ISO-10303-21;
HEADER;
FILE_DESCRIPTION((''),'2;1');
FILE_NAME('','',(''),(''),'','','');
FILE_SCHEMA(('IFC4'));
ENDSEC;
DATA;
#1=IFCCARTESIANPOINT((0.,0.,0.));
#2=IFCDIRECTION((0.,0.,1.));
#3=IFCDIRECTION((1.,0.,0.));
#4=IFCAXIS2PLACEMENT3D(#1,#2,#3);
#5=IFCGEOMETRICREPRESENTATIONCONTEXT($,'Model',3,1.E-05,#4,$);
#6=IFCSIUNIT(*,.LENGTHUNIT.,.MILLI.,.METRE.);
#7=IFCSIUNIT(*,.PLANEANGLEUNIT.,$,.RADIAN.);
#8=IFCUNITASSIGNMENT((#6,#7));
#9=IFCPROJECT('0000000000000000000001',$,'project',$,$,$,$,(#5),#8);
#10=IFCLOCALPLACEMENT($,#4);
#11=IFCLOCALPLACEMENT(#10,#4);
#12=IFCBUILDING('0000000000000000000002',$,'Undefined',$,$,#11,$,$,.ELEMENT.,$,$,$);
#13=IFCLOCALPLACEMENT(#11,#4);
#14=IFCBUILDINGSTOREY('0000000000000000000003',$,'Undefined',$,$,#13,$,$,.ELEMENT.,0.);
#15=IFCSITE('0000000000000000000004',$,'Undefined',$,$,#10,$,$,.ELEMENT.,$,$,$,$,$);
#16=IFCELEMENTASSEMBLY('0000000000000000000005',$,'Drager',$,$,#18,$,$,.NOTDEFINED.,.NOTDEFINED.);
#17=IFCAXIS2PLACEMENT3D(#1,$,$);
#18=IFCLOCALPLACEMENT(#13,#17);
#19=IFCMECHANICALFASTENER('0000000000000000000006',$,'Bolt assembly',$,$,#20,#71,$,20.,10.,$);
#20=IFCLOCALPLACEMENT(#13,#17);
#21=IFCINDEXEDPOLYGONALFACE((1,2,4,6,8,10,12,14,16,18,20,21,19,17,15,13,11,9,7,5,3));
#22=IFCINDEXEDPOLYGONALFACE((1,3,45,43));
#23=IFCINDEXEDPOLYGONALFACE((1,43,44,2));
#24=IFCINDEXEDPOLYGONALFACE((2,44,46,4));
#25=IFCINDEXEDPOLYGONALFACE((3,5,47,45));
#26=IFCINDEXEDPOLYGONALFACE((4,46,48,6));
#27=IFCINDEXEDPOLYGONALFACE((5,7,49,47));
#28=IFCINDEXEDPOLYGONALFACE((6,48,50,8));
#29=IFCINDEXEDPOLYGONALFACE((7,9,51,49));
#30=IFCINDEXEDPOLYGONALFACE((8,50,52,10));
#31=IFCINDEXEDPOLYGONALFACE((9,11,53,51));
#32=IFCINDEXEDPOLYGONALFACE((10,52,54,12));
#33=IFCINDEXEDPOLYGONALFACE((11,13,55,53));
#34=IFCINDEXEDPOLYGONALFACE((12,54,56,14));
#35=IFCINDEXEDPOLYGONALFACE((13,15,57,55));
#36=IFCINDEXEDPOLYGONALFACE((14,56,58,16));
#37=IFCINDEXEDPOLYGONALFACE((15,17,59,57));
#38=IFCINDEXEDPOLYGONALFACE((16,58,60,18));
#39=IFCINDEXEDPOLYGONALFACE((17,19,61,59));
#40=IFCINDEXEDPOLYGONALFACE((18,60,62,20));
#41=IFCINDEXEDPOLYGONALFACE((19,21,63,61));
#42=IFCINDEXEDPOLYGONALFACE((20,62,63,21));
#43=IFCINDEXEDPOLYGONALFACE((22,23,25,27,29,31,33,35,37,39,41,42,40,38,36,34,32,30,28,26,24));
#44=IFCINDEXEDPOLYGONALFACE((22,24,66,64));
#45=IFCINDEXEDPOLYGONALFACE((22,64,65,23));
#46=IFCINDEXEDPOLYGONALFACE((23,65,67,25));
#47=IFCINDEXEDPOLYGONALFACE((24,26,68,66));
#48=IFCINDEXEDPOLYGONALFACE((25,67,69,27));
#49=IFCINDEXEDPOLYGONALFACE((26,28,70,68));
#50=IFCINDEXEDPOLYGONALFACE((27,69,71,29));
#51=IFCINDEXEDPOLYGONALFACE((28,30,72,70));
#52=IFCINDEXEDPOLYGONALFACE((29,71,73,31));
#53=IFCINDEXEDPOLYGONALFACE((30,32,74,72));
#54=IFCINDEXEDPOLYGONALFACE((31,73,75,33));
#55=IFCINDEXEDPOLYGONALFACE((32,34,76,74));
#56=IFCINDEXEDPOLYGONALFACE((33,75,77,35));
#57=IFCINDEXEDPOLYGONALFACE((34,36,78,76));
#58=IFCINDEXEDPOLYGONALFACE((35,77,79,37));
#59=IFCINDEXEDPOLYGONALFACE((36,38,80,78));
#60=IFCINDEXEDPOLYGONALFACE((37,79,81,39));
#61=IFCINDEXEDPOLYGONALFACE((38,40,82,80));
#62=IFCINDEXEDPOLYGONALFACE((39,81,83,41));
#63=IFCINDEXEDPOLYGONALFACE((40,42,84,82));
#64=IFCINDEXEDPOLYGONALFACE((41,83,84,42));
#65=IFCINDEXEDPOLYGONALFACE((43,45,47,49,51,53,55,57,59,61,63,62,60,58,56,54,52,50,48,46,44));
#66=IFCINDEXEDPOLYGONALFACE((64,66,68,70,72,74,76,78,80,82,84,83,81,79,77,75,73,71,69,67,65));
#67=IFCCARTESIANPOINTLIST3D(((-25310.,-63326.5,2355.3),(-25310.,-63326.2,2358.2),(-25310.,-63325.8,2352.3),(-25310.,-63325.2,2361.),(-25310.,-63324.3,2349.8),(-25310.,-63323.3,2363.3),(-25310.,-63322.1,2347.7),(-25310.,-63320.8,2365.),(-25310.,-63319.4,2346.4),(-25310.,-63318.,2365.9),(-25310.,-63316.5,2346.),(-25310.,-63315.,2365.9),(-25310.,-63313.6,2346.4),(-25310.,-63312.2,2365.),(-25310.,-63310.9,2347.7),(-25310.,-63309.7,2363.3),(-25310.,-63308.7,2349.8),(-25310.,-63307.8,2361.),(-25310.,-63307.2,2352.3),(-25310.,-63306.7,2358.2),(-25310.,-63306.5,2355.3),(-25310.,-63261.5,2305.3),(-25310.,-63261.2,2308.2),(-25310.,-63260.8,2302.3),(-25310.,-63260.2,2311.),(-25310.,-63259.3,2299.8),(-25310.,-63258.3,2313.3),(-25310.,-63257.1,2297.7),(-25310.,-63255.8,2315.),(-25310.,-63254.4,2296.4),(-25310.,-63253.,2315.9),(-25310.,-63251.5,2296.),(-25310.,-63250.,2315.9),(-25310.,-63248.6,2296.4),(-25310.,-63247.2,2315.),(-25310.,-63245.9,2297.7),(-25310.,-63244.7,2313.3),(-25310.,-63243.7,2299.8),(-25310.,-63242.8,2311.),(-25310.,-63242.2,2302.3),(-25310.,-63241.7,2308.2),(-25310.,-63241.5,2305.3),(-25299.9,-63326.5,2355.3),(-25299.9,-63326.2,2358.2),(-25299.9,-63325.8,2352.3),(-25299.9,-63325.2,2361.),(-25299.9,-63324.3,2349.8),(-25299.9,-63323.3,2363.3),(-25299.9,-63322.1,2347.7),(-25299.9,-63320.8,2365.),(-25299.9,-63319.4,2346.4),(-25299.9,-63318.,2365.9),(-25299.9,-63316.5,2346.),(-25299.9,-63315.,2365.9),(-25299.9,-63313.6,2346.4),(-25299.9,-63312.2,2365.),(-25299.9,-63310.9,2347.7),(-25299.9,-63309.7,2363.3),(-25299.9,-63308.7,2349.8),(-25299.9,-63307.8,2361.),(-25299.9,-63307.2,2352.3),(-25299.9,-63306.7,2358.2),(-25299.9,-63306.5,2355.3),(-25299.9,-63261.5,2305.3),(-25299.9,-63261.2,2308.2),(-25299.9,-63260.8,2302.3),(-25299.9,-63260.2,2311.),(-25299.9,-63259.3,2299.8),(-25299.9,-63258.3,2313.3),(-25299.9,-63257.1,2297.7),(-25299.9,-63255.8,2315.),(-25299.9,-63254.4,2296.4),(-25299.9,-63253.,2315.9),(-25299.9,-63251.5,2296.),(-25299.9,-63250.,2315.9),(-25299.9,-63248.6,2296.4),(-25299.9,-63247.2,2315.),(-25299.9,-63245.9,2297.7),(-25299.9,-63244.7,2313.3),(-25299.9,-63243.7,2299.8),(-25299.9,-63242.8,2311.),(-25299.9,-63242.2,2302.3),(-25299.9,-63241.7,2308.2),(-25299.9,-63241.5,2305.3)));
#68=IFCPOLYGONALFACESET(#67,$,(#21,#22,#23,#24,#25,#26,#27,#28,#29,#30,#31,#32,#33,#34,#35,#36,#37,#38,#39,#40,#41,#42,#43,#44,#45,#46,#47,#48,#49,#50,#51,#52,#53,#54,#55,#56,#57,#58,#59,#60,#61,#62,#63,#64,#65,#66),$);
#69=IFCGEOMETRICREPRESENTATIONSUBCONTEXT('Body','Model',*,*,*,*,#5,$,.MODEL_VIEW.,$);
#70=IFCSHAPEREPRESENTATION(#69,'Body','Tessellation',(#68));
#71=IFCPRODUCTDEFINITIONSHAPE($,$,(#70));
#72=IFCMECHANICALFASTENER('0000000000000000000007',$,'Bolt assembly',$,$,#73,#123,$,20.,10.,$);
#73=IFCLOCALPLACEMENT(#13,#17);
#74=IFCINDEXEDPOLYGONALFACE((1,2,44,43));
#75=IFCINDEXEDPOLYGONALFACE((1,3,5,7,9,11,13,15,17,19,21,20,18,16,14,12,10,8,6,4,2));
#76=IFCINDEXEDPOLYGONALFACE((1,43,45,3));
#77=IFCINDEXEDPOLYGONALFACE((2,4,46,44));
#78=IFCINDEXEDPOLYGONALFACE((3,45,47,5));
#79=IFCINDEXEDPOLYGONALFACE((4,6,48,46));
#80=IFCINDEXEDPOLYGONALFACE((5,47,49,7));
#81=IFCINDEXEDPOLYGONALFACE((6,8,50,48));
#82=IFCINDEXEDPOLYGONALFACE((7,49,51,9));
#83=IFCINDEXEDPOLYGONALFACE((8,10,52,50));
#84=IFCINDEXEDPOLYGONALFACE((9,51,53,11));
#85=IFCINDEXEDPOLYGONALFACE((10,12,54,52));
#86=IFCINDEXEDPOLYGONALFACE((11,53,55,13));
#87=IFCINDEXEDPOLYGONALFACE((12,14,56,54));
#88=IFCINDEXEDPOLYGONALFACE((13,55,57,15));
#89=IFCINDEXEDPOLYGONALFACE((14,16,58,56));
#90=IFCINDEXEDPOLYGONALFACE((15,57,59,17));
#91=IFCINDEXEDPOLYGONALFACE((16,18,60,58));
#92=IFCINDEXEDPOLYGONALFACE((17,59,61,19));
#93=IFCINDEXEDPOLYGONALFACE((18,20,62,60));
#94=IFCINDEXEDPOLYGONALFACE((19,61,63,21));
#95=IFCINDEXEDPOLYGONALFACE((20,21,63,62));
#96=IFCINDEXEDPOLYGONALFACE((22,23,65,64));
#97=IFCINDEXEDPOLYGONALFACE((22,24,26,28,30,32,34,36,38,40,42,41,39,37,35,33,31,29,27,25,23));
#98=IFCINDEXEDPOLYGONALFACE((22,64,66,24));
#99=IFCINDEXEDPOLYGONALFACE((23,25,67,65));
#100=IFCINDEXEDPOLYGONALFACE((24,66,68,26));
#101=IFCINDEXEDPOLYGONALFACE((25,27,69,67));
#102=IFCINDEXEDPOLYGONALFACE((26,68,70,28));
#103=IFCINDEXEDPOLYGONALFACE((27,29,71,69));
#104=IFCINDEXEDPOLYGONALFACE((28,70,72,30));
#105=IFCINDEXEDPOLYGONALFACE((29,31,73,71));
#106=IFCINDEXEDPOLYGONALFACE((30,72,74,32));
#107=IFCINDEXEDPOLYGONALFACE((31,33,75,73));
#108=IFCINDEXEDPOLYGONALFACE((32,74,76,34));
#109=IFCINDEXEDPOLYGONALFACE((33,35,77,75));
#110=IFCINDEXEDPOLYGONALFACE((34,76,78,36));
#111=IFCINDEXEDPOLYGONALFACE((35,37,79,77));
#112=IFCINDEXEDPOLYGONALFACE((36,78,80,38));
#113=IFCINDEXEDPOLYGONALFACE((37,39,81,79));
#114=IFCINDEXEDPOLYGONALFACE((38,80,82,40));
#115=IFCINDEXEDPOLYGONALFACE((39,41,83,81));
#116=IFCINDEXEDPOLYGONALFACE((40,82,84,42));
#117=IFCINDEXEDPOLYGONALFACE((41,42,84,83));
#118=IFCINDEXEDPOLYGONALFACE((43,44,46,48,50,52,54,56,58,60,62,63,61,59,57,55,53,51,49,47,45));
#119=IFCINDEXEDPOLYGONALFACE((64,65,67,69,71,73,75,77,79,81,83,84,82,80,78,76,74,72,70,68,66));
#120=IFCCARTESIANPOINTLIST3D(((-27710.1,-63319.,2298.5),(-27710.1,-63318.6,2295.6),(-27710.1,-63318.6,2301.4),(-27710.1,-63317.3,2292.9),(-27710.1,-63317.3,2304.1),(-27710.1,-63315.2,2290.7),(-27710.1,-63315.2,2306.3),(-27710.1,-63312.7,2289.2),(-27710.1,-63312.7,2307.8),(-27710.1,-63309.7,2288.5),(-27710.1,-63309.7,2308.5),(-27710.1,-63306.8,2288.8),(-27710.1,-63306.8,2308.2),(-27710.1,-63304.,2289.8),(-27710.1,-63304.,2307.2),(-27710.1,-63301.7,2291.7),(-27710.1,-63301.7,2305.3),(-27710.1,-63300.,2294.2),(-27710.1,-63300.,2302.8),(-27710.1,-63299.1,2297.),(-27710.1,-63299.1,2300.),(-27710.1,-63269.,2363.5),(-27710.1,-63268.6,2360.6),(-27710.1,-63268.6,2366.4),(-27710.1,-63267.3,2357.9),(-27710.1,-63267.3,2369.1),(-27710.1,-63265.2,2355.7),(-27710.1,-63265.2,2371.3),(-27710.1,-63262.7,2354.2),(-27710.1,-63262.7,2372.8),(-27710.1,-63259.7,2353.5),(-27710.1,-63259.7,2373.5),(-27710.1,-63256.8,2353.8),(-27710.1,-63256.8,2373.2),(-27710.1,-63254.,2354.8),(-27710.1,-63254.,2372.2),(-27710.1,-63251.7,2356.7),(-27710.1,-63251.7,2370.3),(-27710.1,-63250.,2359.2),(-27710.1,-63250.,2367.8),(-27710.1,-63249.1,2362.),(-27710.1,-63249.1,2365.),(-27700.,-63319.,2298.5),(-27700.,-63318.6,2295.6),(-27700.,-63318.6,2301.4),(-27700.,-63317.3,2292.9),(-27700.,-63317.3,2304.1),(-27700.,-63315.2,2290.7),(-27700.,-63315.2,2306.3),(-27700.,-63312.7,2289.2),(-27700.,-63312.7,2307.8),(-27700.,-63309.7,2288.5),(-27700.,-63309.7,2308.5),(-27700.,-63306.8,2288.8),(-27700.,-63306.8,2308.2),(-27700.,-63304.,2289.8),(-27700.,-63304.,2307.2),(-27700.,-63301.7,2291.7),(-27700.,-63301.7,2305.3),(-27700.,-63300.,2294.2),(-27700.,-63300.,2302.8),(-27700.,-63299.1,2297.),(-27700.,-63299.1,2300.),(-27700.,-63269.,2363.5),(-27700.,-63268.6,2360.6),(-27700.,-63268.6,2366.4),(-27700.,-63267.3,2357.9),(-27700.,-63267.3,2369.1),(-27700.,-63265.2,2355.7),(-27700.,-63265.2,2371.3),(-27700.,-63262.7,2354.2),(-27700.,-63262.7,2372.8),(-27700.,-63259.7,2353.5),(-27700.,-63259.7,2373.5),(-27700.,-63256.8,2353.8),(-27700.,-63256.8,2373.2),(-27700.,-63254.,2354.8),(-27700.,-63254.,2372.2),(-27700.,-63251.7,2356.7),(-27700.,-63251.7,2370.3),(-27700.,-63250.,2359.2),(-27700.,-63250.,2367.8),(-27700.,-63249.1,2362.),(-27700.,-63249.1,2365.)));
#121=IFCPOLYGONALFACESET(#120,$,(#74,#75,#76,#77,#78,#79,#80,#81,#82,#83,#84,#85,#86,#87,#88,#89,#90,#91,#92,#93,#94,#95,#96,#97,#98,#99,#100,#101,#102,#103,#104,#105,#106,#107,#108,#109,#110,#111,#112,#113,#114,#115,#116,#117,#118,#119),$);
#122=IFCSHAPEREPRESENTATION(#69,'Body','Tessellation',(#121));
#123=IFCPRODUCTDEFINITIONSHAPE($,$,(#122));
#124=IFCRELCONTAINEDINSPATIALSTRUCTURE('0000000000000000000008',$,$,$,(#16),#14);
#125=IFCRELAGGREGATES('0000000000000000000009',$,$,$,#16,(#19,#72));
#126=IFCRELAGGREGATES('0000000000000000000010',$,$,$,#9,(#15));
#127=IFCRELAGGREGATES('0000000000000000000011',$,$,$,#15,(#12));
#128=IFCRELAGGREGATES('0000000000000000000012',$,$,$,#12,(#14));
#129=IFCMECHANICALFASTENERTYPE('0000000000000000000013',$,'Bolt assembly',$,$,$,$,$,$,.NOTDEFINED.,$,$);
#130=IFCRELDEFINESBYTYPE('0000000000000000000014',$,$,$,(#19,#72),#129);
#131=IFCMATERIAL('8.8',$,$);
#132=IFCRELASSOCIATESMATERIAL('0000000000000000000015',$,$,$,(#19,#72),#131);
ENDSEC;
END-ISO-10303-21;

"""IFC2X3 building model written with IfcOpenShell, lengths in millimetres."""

from ifc_helpers import new_model, si_unit, frame, origin_with_axes, origin_2d_with_axis, place, context, subcontext, project, spatial, circle, extrude, source, transform, mapped, material, type_object, element, aggregate, save


model = new_model("IFC2X3")

# Units and contexts
model_context = context("Model", 3, precision=1e-05, world=origin_with_axes())
body_context = subcontext(model_context, "Body", "Model", "MODEL_VIEW")
ifc_project = project(units=[si_unit("LENGTHUNIT", "METRE", prefix="MILLI"), si_unit("PLANEANGLEUNIT", "RADIAN")], contexts=[model_context])

# Site, building, storey
site_placement = place(None, origin_with_axes())
site = spatial("IfcSite", under=ifc_project, at=site_placement, Name="Undefined", CompositionType="ELEMENT")
building_placement = place(site_placement, origin_with_axes())
building = spatial("IfcBuilding", under=site, at=building_placement, Name="Undefined", CompositionType="ELEMENT")
storey_placement = place(building_placement, origin_with_axes())
storey = spatial("IfcBuildingStorey", under=building, at=storey_placement, Name="Undefined", CompositionType="ELEMENT", Elevation=0.0)

# Element assembly
assembly_1_placement = place(storey_placement, origin_with_axes())
assembly_1 = element("IfcElementAssembly", 1, at=assembly_1_placement, inside=storey, Name="Drager", AssemblyPlace="NOTDEFINED", PredefinedType="NOTDEFINED")

# Mechanical fasteners
ifc_material_1 = material(Name="8.8")
mechanical_fastener_type = type_object("IfcMechanicalFastenerType", Name="Bolt assembly")
shared_shape_1 = source(origin_with_axes(), body_context, "Body", "SweptSolid", [
    extrude(circle(Radius=10.0, at=origin_2d_with_axis()), frame((0.0, 0.0, 0.0), z_axis=(0.0, 1.0, 0.0), x_axis=(1.0, 0.0, 0.0)), (0.0, 0.0, 1.0), 10.1),
])
mechanical_fastener_1_placement = place(assembly_1_placement, frame((-25310.0, -63284.0, 2356.0), z_axis=(0.0, -1.0, 0.0), x_axis=(0.0, 0.0, -1.0)))
mechanical_fastener_1 = element("IfcMechanicalFastener", 2, at=mechanical_fastener_1_placement, type_object=mechanical_fastener_type, material=ifc_material_1, Name="Bolt assembly", NominalDiameter=20.0, NominalLength=10.0, context=body_context, shape_type="MappedRepresentation", body=[
    mapped(shared_shape_1, transform((50.0, 0.0, -32.5))),
    mapped(shared_shape_1, transform((0.0, 0.0, 32.5))),
])
mechanical_fastener_2_placement = place(assembly_1_placement, frame((-27700.0, -63259.0, 2331.0), z_axis=(0.0, 0.0, -1.0), x_axis=(0.0, -1.0, 0.0)))
mechanical_fastener_2 = element("IfcMechanicalFastener", 3, at=mechanical_fastener_2_placement, type_object=mechanical_fastener_type, material=ifc_material_1, Name="Bolt assembly", NominalDiameter=20.0, NominalLength=10.0, context=body_context, shape_type="MappedRepresentation", body=[
    mapped(shared_shape_1, transform((0.0, 0.0, -32.5))),
    mapped(shared_shape_1, transform((50.0, 0.0, 32.5))),
])
aggregate(assembly_1, [mechanical_fastener_1, mechanical_fastener_2])

save(model, "model.ifc")
